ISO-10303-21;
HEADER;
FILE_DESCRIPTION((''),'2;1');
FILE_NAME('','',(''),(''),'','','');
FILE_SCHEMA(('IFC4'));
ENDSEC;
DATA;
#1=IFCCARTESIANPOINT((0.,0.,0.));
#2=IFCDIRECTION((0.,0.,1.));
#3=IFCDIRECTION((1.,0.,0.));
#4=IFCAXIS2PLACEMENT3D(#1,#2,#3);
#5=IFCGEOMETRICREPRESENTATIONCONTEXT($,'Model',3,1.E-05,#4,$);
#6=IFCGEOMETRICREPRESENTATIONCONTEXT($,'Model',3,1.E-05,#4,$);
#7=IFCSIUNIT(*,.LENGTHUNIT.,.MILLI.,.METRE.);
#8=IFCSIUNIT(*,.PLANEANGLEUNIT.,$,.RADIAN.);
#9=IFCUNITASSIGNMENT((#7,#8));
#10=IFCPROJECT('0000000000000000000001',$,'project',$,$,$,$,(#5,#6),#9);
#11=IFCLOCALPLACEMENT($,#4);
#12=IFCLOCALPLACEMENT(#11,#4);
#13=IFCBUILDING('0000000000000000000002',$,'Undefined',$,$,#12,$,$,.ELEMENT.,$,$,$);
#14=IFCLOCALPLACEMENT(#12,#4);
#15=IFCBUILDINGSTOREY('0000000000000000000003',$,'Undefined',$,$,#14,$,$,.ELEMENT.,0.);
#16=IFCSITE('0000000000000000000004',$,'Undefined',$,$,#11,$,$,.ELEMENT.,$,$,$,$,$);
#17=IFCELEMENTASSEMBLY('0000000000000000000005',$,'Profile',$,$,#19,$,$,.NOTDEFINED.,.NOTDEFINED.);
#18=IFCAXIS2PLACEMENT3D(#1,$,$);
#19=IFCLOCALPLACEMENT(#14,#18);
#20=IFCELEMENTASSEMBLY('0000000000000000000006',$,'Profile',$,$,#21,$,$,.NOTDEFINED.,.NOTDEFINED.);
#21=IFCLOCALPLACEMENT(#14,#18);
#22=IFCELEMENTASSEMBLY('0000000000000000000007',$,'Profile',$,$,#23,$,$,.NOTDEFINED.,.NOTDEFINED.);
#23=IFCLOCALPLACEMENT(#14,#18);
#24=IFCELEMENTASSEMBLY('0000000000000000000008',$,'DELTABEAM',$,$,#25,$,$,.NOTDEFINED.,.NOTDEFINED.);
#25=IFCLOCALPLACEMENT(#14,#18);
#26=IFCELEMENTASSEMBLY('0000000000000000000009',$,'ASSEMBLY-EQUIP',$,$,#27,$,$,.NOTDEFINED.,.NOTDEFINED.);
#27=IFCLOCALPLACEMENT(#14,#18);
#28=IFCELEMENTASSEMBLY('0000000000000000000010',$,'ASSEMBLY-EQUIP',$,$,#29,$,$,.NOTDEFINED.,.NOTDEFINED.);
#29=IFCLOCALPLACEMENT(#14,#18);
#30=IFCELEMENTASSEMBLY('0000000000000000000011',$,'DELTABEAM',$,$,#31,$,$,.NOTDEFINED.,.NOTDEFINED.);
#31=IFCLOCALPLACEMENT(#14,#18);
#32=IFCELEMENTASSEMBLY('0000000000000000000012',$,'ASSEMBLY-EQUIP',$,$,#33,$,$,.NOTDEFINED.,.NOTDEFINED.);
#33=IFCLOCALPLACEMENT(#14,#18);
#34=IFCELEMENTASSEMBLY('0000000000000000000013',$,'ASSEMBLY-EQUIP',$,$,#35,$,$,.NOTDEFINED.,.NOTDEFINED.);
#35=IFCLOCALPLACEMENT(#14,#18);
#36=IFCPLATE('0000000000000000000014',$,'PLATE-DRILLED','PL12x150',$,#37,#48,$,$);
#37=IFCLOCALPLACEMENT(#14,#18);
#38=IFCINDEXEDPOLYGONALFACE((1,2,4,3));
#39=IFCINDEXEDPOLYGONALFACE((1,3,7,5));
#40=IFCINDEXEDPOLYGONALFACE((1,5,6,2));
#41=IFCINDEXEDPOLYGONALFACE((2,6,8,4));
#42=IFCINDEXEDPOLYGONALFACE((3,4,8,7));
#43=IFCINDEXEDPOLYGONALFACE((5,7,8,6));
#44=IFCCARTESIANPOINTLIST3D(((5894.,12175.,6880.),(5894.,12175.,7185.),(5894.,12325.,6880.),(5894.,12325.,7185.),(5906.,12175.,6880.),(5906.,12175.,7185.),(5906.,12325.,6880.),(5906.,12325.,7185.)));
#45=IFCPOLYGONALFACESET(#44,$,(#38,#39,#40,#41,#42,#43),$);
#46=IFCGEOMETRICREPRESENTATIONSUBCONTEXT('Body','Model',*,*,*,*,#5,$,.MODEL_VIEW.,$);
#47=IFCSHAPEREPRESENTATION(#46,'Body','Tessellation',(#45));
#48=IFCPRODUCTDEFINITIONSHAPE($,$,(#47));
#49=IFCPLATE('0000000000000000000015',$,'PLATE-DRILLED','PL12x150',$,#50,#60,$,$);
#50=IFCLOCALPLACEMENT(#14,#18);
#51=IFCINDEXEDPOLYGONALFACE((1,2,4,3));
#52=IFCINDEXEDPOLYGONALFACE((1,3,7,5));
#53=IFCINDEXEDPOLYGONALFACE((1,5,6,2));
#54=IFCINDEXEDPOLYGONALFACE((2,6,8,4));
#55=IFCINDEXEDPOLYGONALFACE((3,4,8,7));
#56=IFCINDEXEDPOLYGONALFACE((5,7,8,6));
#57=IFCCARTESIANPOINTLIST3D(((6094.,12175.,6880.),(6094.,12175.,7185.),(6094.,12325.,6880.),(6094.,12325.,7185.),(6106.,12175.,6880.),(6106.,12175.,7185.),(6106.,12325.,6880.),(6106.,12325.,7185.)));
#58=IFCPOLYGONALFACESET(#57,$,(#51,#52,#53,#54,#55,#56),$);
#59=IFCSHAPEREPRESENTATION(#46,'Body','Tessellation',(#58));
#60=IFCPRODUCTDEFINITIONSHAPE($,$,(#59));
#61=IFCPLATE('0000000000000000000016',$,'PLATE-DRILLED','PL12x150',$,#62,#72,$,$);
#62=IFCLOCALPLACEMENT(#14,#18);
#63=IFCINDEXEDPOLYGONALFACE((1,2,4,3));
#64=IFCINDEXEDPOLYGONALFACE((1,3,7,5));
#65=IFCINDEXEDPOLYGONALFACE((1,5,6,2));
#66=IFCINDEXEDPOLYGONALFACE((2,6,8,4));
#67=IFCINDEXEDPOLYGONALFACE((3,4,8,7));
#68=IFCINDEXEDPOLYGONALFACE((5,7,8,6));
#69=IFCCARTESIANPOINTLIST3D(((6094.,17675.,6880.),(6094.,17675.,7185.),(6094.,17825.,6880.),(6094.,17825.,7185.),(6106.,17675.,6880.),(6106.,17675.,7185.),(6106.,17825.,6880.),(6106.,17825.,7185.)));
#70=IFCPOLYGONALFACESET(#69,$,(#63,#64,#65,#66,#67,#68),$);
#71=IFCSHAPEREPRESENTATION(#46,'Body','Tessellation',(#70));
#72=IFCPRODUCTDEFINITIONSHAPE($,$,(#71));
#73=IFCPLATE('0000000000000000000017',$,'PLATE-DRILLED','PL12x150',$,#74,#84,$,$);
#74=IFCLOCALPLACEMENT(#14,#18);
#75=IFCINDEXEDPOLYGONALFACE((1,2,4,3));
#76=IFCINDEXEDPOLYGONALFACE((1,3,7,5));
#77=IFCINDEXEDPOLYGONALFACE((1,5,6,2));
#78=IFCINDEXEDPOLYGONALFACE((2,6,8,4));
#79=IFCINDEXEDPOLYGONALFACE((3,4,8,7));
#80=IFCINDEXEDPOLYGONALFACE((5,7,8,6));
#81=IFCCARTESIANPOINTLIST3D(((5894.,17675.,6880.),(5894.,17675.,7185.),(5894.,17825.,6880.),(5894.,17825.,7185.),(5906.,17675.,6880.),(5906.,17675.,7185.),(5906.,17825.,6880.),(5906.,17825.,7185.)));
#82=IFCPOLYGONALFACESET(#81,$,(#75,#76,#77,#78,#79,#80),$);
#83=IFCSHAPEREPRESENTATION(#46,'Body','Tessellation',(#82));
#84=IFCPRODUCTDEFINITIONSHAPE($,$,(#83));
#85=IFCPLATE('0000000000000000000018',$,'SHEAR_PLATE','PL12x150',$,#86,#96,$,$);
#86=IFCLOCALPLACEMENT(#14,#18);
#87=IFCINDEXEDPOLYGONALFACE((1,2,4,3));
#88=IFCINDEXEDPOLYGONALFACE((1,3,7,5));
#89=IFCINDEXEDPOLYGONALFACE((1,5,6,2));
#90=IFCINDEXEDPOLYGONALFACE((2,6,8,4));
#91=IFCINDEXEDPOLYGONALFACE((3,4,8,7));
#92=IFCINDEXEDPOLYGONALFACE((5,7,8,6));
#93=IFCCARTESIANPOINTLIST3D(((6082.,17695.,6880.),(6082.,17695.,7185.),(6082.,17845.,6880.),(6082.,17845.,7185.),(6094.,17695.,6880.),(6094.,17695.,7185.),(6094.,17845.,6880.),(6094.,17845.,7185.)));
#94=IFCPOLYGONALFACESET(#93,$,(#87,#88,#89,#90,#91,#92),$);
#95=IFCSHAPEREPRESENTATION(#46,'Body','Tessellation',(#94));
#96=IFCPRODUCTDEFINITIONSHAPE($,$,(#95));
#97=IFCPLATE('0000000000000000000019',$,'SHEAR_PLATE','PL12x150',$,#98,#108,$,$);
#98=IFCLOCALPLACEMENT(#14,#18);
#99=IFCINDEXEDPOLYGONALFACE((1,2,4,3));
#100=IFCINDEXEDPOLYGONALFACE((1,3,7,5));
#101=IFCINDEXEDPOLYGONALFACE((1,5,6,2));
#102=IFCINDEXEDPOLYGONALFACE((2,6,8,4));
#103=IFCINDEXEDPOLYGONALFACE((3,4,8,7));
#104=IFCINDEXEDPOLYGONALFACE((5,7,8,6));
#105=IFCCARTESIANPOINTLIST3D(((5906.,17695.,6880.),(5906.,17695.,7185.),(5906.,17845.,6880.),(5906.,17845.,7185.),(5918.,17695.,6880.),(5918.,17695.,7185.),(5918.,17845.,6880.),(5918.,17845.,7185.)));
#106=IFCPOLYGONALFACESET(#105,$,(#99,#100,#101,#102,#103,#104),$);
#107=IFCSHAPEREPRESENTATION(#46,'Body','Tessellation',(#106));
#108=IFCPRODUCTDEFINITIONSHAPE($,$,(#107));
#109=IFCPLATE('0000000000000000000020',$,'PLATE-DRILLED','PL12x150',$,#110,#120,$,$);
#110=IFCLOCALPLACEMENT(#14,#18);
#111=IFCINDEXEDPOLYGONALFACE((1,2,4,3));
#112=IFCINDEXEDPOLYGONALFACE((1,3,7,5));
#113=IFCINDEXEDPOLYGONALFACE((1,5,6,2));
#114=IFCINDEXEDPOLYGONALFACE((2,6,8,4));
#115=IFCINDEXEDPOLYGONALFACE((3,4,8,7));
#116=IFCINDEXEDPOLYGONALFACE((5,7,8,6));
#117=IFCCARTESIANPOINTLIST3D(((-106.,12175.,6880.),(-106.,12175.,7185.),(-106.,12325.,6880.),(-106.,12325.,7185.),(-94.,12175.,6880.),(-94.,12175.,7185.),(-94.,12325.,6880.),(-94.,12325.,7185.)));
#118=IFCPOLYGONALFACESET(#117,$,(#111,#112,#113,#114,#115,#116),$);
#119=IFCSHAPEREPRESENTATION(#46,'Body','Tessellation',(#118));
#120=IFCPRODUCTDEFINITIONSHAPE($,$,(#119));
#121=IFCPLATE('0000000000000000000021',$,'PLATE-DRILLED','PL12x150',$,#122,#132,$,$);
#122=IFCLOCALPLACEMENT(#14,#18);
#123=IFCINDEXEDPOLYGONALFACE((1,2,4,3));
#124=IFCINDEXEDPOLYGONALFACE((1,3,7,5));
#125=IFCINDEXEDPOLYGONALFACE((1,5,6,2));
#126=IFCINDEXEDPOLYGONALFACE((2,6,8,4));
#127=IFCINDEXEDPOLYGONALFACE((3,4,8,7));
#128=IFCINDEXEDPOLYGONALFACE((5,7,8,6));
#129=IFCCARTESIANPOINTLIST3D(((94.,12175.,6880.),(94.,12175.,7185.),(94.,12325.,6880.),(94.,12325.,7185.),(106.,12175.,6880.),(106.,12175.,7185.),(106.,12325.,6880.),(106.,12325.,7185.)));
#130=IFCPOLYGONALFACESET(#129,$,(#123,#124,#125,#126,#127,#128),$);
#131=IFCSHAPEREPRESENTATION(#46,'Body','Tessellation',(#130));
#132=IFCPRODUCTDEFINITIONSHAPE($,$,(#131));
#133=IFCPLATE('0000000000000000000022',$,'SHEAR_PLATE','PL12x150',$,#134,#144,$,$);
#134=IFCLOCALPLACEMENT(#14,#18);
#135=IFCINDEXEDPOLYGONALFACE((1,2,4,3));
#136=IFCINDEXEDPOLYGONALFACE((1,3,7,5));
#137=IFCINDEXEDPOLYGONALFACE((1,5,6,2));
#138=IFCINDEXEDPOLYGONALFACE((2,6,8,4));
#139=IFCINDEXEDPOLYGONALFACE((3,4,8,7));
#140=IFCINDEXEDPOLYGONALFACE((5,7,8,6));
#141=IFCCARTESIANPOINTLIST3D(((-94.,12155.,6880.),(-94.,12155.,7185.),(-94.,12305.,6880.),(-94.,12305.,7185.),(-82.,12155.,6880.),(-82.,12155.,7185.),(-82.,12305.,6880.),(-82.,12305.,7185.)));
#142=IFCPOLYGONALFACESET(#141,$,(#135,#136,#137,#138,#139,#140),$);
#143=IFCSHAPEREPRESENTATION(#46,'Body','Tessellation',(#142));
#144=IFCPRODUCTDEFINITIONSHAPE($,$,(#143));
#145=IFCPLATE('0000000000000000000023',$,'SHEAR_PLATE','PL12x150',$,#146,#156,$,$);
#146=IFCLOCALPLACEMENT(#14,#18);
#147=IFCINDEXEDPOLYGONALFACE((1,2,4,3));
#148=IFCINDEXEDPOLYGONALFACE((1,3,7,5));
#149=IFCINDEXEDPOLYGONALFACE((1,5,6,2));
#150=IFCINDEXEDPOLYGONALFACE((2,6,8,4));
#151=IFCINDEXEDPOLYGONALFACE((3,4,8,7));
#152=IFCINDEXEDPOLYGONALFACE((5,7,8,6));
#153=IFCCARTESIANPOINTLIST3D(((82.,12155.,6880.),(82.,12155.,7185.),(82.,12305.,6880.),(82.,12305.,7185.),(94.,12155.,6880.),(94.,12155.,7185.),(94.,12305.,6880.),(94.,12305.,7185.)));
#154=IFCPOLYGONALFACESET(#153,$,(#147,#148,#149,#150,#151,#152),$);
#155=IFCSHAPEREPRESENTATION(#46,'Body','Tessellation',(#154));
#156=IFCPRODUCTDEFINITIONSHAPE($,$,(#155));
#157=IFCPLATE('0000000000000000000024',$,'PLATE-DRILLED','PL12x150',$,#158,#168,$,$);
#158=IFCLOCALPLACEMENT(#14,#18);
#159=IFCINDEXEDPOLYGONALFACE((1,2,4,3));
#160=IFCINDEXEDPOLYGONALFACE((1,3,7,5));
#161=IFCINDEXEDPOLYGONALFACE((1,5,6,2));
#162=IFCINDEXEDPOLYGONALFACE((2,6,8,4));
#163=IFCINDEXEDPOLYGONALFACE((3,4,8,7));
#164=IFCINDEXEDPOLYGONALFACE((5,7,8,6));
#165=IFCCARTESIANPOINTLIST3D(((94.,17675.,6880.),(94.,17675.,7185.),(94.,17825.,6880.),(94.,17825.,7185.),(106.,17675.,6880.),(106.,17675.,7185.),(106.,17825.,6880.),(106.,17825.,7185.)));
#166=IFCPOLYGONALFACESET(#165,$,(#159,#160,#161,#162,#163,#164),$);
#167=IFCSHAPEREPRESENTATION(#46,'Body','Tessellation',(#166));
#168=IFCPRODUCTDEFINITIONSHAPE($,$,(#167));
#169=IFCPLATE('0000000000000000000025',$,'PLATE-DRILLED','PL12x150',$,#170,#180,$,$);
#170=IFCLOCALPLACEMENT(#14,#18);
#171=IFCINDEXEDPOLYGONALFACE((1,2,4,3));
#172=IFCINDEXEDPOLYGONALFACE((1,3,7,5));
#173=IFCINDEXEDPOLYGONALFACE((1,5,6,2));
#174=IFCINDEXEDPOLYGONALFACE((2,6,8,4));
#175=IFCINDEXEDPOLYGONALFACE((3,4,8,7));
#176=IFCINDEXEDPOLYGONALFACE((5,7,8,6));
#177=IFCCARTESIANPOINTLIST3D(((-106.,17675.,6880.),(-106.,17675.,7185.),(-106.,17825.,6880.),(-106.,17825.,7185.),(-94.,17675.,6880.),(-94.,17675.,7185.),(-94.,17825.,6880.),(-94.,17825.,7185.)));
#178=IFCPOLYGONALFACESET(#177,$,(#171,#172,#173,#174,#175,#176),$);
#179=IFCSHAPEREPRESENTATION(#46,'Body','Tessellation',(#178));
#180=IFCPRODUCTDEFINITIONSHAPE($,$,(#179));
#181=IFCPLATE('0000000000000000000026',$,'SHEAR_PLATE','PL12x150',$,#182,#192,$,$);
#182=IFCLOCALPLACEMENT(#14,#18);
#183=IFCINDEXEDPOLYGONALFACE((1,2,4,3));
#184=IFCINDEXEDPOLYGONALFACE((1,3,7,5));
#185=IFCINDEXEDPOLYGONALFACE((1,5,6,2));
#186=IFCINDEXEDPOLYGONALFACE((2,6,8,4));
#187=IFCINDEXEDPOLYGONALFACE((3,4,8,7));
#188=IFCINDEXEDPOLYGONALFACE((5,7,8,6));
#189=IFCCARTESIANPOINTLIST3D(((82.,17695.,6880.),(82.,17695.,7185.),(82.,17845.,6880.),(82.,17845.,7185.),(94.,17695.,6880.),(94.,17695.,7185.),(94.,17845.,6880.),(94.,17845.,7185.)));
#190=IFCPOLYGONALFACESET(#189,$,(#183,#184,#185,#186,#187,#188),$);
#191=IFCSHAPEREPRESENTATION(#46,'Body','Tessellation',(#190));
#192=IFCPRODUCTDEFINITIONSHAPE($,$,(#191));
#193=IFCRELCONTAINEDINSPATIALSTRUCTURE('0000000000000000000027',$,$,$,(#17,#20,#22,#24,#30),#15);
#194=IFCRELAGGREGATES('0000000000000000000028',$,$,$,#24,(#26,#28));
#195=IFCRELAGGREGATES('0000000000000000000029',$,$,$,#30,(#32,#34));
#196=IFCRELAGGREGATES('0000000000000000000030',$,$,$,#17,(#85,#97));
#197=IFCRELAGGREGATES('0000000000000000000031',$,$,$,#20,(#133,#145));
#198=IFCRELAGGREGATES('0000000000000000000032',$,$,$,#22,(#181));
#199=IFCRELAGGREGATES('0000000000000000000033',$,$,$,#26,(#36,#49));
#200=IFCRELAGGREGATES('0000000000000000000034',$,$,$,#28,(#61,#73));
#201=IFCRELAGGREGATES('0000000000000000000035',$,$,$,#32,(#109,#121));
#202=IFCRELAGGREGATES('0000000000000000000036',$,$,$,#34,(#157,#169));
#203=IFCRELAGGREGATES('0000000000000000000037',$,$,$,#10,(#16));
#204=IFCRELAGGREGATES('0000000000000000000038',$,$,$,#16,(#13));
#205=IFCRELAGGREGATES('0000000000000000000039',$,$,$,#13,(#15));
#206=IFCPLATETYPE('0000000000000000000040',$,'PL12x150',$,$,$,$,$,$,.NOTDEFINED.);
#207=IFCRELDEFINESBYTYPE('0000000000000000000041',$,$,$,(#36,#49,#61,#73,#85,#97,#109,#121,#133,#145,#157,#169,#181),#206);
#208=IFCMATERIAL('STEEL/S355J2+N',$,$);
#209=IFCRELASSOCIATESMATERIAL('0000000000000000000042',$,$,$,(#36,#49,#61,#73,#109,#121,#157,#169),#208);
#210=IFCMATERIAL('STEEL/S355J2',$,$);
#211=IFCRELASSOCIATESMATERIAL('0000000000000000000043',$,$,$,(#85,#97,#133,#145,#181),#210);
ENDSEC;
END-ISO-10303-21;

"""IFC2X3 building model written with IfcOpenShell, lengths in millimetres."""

from ifc_helpers import new_model, si_unit, frame, origin_with_axes, place, context, subcontext, project, spatial, polyline, outline, extrude, material, type_object, element, aggregate, save


model = new_model("IFC2X3")

# Units and contexts
model_context_1 = context("Model", 3, precision=1e-05, world=origin_with_axes())
model_context_2 = context("Model", 3, precision=1e-05, world=origin_with_axes())
body_context = subcontext(model_context_1, "Body", "Model", "MODEL_VIEW")
ifc_project = project(units=[si_unit("LENGTHUNIT", "METRE", prefix="MILLI"), si_unit("PLANEANGLEUNIT", "RADIAN")], contexts=[model_context_1, model_context_2])

# Site, building, storey
site_placement = place(None, origin_with_axes())
site = spatial("IfcSite", under=ifc_project, at=site_placement, Name="Undefined", CompositionType="ELEMENT")
building_placement = place(site_placement, origin_with_axes())
building = spatial("IfcBuilding", under=site, at=building_placement, Name="Undefined", CompositionType="ELEMENT")
storey_placement = place(building_placement, origin_with_axes())
storey = spatial("IfcBuildingStorey", under=building, at=storey_placement, Name="Undefined", CompositionType="ELEMENT", Elevation=0.0)

# Element assemblies
ifc_material_1 = material(Name="STEEL/S355J2")
assembly_1_placement = place(storey_placement, origin_with_axes())
assembly_1 = element("IfcElementAssembly", 1, at=assembly_1_placement, inside=storey, Name="Profile", AssemblyPlace="NOTDEFINED", PredefinedType="NOTDEFINED")
assembly_2_placement = place(storey_placement, origin_with_axes())
assembly_2 = element("IfcElementAssembly", 2, at=assembly_2_placement, inside=storey, Name="Profile", AssemblyPlace="NOTDEFINED", PredefinedType="NOTDEFINED")
assembly_3_placement = place(storey_placement, origin_with_axes())
assembly_3 = element("IfcElementAssembly", 3, at=assembly_3_placement, inside=storey, Name="Profile", AssemblyPlace="NOTDEFINED", PredefinedType="NOTDEFINED")

# Element assemblies
assembly_4_placement = place(storey_placement, origin_with_axes())
assembly_4 = element("IfcElementAssembly", 4, at=assembly_4_placement, inside=storey, Name="DELTABEAM", AssemblyPlace="NOTDEFINED", PredefinedType="NOTDEFINED")
assembly_5_placement = place(assembly_4_placement, origin_with_axes())
assembly_5 = element("IfcElementAssembly", 5, at=assembly_5_placement, Name="ASSEMBLY-EQUIP", AssemblyPlace="NOTDEFINED", PredefinedType="NOTDEFINED")
ifc_material_2 = material(Name="STEEL/S355J2+N")
assembly_6_placement = place(assembly_4_placement, origin_with_axes())
assembly_6 = element("IfcElementAssembly", 6, at=assembly_6_placement, Name="ASSEMBLY-EQUIP", AssemblyPlace="NOTDEFINED", PredefinedType="NOTDEFINED")
aggregate(assembly_4, [assembly_5, assembly_6])
assembly_7_placement = place(storey_placement, origin_with_axes())
assembly_7 = element("IfcElementAssembly", 7, at=assembly_7_placement, inside=storey, Name="DELTABEAM", AssemblyPlace="NOTDEFINED", PredefinedType="NOTDEFINED")
assembly_8_placement = place(assembly_7_placement, origin_with_axes())
assembly_8 = element("IfcElementAssembly", 8, at=assembly_8_placement, Name="ASSEMBLY-EQUIP", AssemblyPlace="NOTDEFINED", PredefinedType="NOTDEFINED")
assembly_9_placement = place(assembly_7_placement, origin_with_axes())
assembly_9 = element("IfcElementAssembly", 9, at=assembly_9_placement, Name="ASSEMBLY-EQUIP", AssemblyPlace="NOTDEFINED", PredefinedType="NOTDEFINED")
aggregate(assembly_7, [assembly_8, assembly_9])

# Plates
plate_type_1 = type_object("IfcPlateType", Name="PL12x150", PredefinedType="NOTDEFINED")
plate_1_placement = place(assembly_5_placement, frame((5900.0, 12325.0, 7185.0), z_axis=(1.0, 0.0, 0.0), x_axis=(0.0, -1.0, 0.0)))
plate_1 = element("IfcPlate", 10, at=plate_1_placement, type_object=plate_type_1, material=ifc_material_2, Name="PLATE-DRILLED", Description="PL12x150", context=body_context, shape_type="SweptSolid", body=[
    extrude(outline(polyline([(0.0, 0.0), (150.0, 0.0), (150.0, 0.0), (150.0, 305.0), (150.0, 305.0), (0.0, 305.0), (0.0, 305.0), (0.0, 0.0)])), frame((0.0, 0.0, -6.0), z_axis=(0.0, 0.0, 1.0), x_axis=(1.0, 0.0, 0.0)), (0.0, 0.0, 1.0), 12.0),
])
plate_2_placement = place(assembly_5_placement, frame((6100.0, 12325.0, 7185.0), z_axis=(1.0, 0.0, 0.0), x_axis=(0.0, -1.0, 0.0)))
plate_2 = element("IfcPlate", 11, at=plate_2_placement, type_object=plate_type_1, material=ifc_material_2, Name="PLATE-DRILLED", Description="PL12x150", context=body_context, shape_type="SweptSolid", body=[
    extrude(outline(polyline([(0.0, 0.0), (150.0, 0.0), (150.0, 0.0), (150.0, 305.0), (150.0, 305.0), (0.0, 305.0), (0.0, 305.0), (0.0, 0.0)])), frame((0.0, 0.0, -6.0), z_axis=(0.0, 0.0, 1.0), x_axis=(1.0, 0.0, 0.0)), (0.0, 0.0, 1.0), 12.0),
])
plate_3_placement = place(assembly_6_placement, frame((6100.0, 17675.0, 7185.0), z_axis=(-1.0, 0.0, 0.0), x_axis=(0.0, 1.0, 0.0)))
plate_3 = element("IfcPlate", 12, at=plate_3_placement, type_object=plate_type_1, material=ifc_material_2, Name="PLATE-DRILLED", Description="PL12x150", context=body_context, shape_type="SweptSolid", body=[
    extrude(outline(polyline([(0.0, 0.0), (150.0, 0.0), (150.0, 0.0), (150.0, 305.0), (150.0, 305.0), (0.0, 305.0), (0.0, 305.0), (0.0, 0.0)])), frame((0.0, 0.0, -6.0), z_axis=(0.0, 0.0, 1.0), x_axis=(1.0, 0.0, 0.0)), (0.0, 0.0, 1.0), 12.0),
])
plate_4_placement = place(assembly_6_placement, frame((5900.0, 17675.0, 7185.0), z_axis=(-1.0, 0.0, 0.0), x_axis=(0.0, 1.0, 0.0)))
plate_4 = element("IfcPlate", 13, at=plate_4_placement, type_object=plate_type_1, material=ifc_material_2, Name="PLATE-DRILLED", Description="PL12x150", context=body_context, shape_type="SweptSolid", body=[
    extrude(outline(polyline([(0.0, 0.0), (150.0, 0.0), (150.0, 0.0), (150.0, 305.0), (150.0, 305.0), (0.0, 305.0), (0.0, 305.0), (0.0, 0.0)])), frame((0.0, 0.0, -6.0), z_axis=(0.0, 0.0, 1.0), x_axis=(1.0, 0.0, 0.0)), (0.0, 0.0, 1.0), 12.0),
])
plate_5_placement = place(assembly_1_placement, frame((6088.0, 17845.0, 7185.0), z_axis=(1.0, 0.0, 0.0), x_axis=(0.0, -1.0, 0.0)))
plate_5 = element("IfcPlate", 14, at=plate_5_placement, type_object=plate_type_1, material=ifc_material_1, Name="SHEAR_PLATE", Description="PL12x150", context=body_context, shape_type="SweptSolid", body=[
    extrude(outline(polyline([(0.0, 0.0), (150.0, 0.0), (150.0, 0.0), (150.0, 305.0), (150.0, 305.0), (0.0, 305.0), (0.0, 305.0), (0.0, 0.0)])), frame((0.0, 0.0, -6.0), z_axis=(0.0, 0.0, 1.0), x_axis=(1.0, 0.0, 0.0)), (0.0, 0.0, 1.0), 12.0),
])
plate_6_placement = place(assembly_1_placement, frame((5912.0, 17845.0, 7185.0), z_axis=(1.0, 0.0, 0.0), x_axis=(0.0, -1.0, 0.0)))
plate_6 = element("IfcPlate", 15, at=plate_6_placement, type_object=plate_type_1, material=ifc_material_1, Name="SHEAR_PLATE", Description="PL12x150", context=body_context, shape_type="SweptSolid", body=[
    extrude(outline(polyline([(0.0, 0.0), (150.0, 0.0), (150.0, 0.0), (150.0, 305.0), (150.0, 305.0), (0.0, 305.0), (0.0, 305.0), (0.0, 0.0)])), frame((0.0, 0.0, -6.0), z_axis=(0.0, 0.0, 1.0), x_axis=(1.0, 0.0, 0.0)), (0.0, 0.0, 1.0), 12.0),
])
aggregate(assembly_1, [plate_5, plate_6])
plate_7_placement = place(assembly_8_placement, frame((-100.0, 12325.0, 7185.0), z_axis=(1.0, 0.0, 0.0), x_axis=(0.0, -1.0, 0.0)))
plate_7 = element("IfcPlate", 16, at=plate_7_placement, type_object=plate_type_1, material=ifc_material_2, Name="PLATE-DRILLED", Description="PL12x150", context=body_context, shape_type="SweptSolid", body=[
    extrude(outline(polyline([(0.0, 0.0), (150.0, 0.0), (150.0, 0.0), (150.0, 305.0), (150.0, 305.0), (0.0, 305.0), (0.0, 305.0), (0.0, 0.0)])), frame((0.0, 0.0, -6.0), z_axis=(0.0, 0.0, 1.0), x_axis=(1.0, 0.0, 0.0)), (0.0, 0.0, 1.0), 12.0),
])
plate_8_placement = place(assembly_8_placement, frame((100.0, 12325.0, 7185.0), z_axis=(1.0, 0.0, 0.0), x_axis=(0.0, -1.0, 0.0)))
plate_8 = element("IfcPlate", 17, at=plate_8_placement, type_object=plate_type_1, material=ifc_material_2, Name="PLATE-DRILLED", Description="PL12x150", context=body_context, shape_type="SweptSolid", body=[
    extrude(outline(polyline([(0.0, 0.0), (150.0, 0.0), (150.0, 0.0), (150.0, 305.0), (150.0, 305.0), (0.0, 305.0), (0.0, 305.0), (0.0, 0.0)])), frame((0.0, 0.0, -6.0), z_axis=(0.0, 0.0, 1.0), x_axis=(1.0, 0.0, 0.0)), (0.0, 0.0, 1.0), 12.0),
])
plate_9_placement = place(assembly_2_placement, frame((-88.0, 12155.0, 7185.0), z_axis=(-1.0, 0.0, 0.0), x_axis=(0.0, 1.0, 0.0)))
plate_9 = element("IfcPlate", 18, at=plate_9_placement, type_object=plate_type_1, material=ifc_material_1, Name="SHEAR_PLATE", Description="PL12x150", context=body_context, shape_type="SweptSolid", body=[
    extrude(outline(polyline([(0.0, 0.0), (150.0, 0.0), (150.0, 0.0), (150.0, 305.0), (150.0, 305.0), (0.0, 305.0), (0.0, 305.0), (0.0, 0.0)])), frame((0.0, 0.0, -6.0), z_axis=(0.0, 0.0, 1.0), x_axis=(1.0, 0.0, 0.0)), (0.0, 0.0, 1.0), 12.0),
])
plate_10_placement = place(assembly_2_placement, frame((88.0, 12155.0, 7185.0), z_axis=(-1.0, 0.0, 0.0), x_axis=(0.0, 1.0, 0.0)))
plate_10 = element("IfcPlate", 19, at=plate_10_placement, type_object=plate_type_1, material=ifc_material_1, Name="SHEAR_PLATE", Description="PL12x150", context=body_context, shape_type="SweptSolid", body=[
    extrude(outline(polyline([(0.0, 0.0), (150.0, 0.0), (150.0, 0.0), (150.0, 305.0), (150.0, 305.0), (0.0, 305.0), (0.0, 305.0), (0.0, 0.0)])), frame((0.0, 0.0, -6.0), z_axis=(0.0, 0.0, 1.0), x_axis=(1.0, 0.0, 0.0)), (0.0, 0.0, 1.0), 12.0),
])
aggregate(assembly_2, [plate_9, plate_10])
plate_11_placement = place(assembly_9_placement, frame((100.0, 17675.0, 7185.0), z_axis=(-1.0, 0.0, 0.0), x_axis=(0.0, 1.0, 0.0)))
plate_11 = element("IfcPlate", 20, at=plate_11_placement, type_object=plate_type_1, material=ifc_material_2, Name="PLATE-DRILLED", Description="PL12x150", context=body_context, shape_type="SweptSolid", body=[
    extrude(outline(polyline([(0.0, 0.0), (150.0, 0.0), (150.0, 0.0), (150.0, 305.0), (150.0, 305.0), (0.0, 305.0), (0.0, 305.0), (0.0, 0.0)])), frame((0.0, 0.0, -6.0), z_axis=(0.0, 0.0, 1.0), x_axis=(1.0, 0.0, 0.0)), (0.0, 0.0, 1.0), 12.0),
])
plate_12_placement = place(assembly_9_placement, frame((-100.0, 17675.0, 7185.0), z_axis=(-1.0, 0.0, 0.0), x_axis=(0.0, 1.0, 0.0)))
plate_12 = element("IfcPlate", 21, at=plate_12_placement, type_object=plate_type_1, material=ifc_material_2, Name="PLATE-DRILLED", Description="PL12x150", context=body_context, shape_type="SweptSolid", body=[
    extrude(outline(polyline([(0.0, 0.0), (150.0, 0.0), (150.0, 0.0), (150.0, 305.0), (150.0, 305.0), (0.0, 305.0), (0.0, 305.0), (0.0, 0.0)])), frame((0.0, 0.0, -6.0), z_axis=(0.0, 0.0, 1.0), x_axis=(1.0, 0.0, 0.0)), (0.0, 0.0, 1.0), 12.0),
])
plate_13_placement = place(assembly_3_placement, frame((88.0, 17845.0, 7185.0), z_axis=(1.0, 0.0, 0.0), x_axis=(0.0, -1.0, 0.0)))
plate_13 = element("IfcPlate", 22, at=plate_13_placement, type_object=plate_type_1, material=ifc_material_1, Name="SHEAR_PLATE", Description="PL12x150", context=body_context, shape_type="SweptSolid", body=[
    extrude(outline(polyline([(0.0, 0.0), (150.0, 0.0), (150.0, 0.0), (150.0, 305.0), (150.0, 305.0), (0.0, 305.0), (0.0, 305.0), (0.0, 0.0)])), frame((0.0, 0.0, -6.0), z_axis=(0.0, 0.0, 1.0), x_axis=(1.0, 0.0, 0.0)), (0.0, 0.0, 1.0), 12.0),
])
aggregate(assembly_3, [plate_13])

aggregate(assembly_5, [plate_1, plate_2])
aggregate(assembly_6, [plate_3, plate_4])
aggregate(assembly_8, [plate_7, plate_8])
aggregate(assembly_9, [plate_11, plate_12])

save(model, "model.ifc")
